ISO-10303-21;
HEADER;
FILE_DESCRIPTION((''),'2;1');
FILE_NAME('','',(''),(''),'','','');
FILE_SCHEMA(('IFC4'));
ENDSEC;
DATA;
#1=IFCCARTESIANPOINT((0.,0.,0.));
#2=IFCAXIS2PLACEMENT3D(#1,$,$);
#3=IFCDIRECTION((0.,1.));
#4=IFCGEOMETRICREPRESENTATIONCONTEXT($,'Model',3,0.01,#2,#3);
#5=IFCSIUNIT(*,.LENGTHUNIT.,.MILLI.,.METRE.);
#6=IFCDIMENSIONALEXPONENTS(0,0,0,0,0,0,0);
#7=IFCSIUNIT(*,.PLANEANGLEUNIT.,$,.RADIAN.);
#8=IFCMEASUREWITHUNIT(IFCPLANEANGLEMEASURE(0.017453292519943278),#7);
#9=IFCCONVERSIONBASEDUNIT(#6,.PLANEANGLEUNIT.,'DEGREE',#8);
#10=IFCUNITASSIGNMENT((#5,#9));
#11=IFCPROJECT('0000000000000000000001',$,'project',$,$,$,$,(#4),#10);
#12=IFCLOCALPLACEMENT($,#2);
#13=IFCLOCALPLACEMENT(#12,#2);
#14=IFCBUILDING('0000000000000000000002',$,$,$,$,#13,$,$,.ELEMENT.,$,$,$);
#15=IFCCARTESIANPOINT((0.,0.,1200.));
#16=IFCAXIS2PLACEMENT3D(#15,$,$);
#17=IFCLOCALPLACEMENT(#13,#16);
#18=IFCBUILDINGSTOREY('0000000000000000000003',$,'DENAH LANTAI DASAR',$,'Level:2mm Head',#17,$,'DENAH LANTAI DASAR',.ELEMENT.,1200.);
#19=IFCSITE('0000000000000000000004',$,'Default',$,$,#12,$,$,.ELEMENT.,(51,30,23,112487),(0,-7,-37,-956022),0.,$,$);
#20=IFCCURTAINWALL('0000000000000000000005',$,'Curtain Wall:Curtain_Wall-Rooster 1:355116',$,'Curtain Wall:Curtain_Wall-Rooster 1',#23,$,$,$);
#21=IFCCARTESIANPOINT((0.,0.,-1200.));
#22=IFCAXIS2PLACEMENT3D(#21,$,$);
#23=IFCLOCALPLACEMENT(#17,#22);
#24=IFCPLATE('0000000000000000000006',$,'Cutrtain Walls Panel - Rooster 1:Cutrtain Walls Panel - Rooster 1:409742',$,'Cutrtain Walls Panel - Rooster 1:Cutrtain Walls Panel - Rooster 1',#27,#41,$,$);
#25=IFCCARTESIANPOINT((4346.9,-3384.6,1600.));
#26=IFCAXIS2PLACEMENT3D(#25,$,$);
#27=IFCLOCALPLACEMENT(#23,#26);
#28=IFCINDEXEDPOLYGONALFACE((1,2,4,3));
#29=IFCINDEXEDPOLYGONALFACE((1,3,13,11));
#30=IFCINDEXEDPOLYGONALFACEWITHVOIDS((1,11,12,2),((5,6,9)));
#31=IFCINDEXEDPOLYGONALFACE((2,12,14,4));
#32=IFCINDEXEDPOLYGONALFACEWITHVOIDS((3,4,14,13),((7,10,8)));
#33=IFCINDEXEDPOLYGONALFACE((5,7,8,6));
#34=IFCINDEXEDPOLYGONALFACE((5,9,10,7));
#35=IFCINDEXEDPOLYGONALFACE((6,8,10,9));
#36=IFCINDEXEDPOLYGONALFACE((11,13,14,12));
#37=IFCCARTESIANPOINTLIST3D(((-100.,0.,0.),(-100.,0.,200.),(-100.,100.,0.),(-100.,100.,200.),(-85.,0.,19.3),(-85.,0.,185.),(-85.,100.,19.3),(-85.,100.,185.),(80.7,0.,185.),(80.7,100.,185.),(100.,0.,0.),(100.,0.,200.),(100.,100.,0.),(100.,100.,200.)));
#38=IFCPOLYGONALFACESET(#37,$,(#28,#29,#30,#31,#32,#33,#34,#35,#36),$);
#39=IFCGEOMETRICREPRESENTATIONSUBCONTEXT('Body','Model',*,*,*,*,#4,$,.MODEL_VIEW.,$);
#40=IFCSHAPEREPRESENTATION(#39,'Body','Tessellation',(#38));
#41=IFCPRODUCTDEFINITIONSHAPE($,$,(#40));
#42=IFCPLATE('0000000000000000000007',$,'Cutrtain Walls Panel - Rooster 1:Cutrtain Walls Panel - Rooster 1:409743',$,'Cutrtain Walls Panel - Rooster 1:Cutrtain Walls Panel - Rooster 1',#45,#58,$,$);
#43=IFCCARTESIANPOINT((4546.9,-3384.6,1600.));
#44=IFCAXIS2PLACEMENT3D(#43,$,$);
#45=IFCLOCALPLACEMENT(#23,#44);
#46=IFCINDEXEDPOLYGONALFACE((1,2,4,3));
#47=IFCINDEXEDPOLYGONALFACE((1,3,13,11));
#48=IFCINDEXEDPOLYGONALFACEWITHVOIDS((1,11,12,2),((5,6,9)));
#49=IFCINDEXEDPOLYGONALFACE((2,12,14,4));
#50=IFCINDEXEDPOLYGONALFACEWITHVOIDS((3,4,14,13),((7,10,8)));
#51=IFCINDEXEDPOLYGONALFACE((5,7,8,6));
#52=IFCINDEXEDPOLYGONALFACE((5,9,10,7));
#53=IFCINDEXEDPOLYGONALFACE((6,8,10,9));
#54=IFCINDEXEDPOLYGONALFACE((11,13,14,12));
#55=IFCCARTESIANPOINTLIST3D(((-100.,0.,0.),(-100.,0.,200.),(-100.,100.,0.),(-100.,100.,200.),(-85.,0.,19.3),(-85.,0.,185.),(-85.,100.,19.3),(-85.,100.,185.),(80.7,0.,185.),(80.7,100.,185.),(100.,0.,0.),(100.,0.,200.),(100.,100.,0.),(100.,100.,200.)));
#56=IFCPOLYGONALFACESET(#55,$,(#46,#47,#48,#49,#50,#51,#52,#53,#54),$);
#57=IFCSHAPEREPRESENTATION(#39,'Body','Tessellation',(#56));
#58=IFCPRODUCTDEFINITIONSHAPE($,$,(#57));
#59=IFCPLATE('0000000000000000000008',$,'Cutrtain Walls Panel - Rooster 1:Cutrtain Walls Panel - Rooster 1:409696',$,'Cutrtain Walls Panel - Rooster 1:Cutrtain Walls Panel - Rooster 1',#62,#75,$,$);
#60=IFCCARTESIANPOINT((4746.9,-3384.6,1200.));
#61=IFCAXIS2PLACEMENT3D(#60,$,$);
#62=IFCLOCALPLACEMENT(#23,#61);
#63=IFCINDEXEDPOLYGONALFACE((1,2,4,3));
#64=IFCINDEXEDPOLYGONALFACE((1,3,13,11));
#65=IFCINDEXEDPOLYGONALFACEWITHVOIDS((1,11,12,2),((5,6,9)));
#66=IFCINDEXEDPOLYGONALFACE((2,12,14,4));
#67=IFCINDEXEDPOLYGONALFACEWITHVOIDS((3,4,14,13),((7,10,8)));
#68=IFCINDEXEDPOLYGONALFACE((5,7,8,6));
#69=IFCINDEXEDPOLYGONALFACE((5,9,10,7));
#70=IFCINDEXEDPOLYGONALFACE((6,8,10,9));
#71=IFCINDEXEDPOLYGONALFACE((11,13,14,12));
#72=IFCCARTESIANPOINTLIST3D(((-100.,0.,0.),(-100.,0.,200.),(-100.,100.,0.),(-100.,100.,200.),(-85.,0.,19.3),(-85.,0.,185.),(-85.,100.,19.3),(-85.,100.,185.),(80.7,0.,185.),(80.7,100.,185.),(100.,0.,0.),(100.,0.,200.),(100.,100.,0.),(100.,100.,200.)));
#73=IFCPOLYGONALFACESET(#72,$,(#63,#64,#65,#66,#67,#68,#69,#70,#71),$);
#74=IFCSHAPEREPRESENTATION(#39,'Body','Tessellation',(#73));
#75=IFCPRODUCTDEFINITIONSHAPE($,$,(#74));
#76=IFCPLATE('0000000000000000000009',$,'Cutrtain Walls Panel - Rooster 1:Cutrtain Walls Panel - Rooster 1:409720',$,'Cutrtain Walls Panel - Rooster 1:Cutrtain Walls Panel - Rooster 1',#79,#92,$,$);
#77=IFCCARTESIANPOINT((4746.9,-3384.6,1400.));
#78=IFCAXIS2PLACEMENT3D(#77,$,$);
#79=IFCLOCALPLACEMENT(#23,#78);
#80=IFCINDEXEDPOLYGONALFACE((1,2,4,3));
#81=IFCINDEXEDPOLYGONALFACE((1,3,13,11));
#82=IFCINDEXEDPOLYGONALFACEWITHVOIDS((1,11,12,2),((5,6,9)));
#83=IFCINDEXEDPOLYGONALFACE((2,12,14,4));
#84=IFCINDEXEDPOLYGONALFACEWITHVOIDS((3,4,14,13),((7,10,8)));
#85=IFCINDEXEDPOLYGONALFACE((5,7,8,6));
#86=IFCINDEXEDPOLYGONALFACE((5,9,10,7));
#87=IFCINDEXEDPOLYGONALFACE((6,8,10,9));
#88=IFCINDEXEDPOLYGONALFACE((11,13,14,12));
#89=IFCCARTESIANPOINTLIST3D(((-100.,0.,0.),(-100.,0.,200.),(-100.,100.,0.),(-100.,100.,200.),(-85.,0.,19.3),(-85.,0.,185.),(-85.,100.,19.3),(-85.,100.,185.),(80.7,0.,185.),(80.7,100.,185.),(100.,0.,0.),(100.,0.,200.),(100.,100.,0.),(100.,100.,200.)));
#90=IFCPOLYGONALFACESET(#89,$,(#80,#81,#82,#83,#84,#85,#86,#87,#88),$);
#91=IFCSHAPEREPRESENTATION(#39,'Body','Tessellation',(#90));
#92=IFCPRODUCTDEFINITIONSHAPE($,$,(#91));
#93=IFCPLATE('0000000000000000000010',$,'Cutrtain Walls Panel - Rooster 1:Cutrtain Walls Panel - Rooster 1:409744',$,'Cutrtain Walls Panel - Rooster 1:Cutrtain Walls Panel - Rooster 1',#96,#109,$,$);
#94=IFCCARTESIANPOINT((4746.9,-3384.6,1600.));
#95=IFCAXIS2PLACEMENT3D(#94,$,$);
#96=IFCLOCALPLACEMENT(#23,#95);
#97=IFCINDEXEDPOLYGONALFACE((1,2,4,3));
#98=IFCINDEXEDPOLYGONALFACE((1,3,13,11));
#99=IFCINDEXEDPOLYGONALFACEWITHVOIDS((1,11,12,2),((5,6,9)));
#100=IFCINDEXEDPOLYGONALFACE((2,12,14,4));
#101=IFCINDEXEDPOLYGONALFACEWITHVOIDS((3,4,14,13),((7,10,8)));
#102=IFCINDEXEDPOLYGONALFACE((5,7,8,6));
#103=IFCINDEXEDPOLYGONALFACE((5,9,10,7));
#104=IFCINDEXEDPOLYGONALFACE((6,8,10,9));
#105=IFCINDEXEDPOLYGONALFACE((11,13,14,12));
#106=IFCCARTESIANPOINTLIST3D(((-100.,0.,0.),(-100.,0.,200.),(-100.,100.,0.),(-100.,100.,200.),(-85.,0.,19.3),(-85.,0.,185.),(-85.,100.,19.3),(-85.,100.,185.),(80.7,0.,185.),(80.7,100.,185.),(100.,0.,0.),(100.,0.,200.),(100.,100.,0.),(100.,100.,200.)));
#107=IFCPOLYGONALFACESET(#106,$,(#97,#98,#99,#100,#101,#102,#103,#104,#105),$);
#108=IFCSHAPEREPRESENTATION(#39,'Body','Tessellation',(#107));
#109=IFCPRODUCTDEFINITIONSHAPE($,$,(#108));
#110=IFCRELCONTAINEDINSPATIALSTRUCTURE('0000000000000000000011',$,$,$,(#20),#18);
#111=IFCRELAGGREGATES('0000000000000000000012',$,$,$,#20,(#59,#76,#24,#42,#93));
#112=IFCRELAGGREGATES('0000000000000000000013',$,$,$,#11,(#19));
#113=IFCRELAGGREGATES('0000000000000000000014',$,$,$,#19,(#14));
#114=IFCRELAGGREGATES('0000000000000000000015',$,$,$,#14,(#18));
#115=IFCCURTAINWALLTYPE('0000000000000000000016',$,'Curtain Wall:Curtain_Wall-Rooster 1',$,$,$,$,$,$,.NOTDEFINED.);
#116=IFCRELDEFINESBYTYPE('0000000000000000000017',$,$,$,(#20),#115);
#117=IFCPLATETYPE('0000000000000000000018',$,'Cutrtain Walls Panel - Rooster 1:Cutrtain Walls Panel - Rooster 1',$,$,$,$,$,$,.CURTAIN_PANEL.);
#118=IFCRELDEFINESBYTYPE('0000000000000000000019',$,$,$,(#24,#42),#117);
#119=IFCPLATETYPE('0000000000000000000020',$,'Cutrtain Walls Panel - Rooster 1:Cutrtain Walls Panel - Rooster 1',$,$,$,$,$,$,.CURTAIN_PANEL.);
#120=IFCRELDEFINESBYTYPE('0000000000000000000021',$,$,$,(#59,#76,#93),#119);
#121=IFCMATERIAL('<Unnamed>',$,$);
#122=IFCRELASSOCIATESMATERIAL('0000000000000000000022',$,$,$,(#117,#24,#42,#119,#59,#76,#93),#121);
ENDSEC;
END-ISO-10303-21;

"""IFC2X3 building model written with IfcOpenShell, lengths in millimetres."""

from ifc_helpers import new_model, entity, si_unit, converted_unit, direction, frame, origin, place, context, subcontext, project, spatial, polyline, outline, extrude, source, transform, mapped, material, type_object, type_shapes, element, aggregate, save


model = new_model("IFC2X3")

# Units and contexts
model_context = context("Model", 3, precision=0.01, world=origin(), true_north=direction((0.0, 1.0)))
body_context = subcontext(model_context, "Body", "Model", "MODEL_VIEW")
ifc_project = project(units=[si_unit("LENGTHUNIT", "METRE", prefix="MILLI"), converted_unit("PLANEANGLEUNIT", "DEGREE", entity("IfcPlaneAngleMeasure", 0.017453292519943278), si_unit("PLANEANGLEUNIT", "RADIAN"), dimensions=[0, 0, 0, 0, 0, 0, 0])], contexts=[model_context])

# Site, building, storey
site_placement = place(None, origin())
site = spatial("IfcSite", under=ifc_project, at=site_placement, Name="Default", CompositionType="ELEMENT", RefLatitude=(51, 30, 23, 112487), RefLongitude=(0, -7, -37, -956022), RefElevation=0.0)
building_placement = place(site_placement, origin())
building = spatial("IfcBuilding", under=site, at=building_placement, CompositionType="ELEMENT")
storey_placement = place(building_placement, frame((0.0, 0.0, 1200.0)))
storey = spatial("IfcBuildingStorey", under=building, at=storey_placement, Name="DENAH LANTAI DASAR", ObjectType="Level:2mm Head", LongName="DENAH LANTAI DASAR", CompositionType="ELEMENT", Elevation=1200.0)

# Curtain wall, plates
curtain_wall_type = type_object("IfcCurtainWallType", Name="Curtain Wall:Curtain_Wall-Rooster 1", PredefinedType="NOTDEFINED")
curtain_wall_placement = place(storey_placement, frame((0.0, 0.0, -1200.0)))
curtain_wall = element("IfcCurtainWall", 1, at=curtain_wall_placement, inside=storey, type_object=curtain_wall_type, Name="Curtain Wall:Curtain_Wall-Rooster 1:355116", ObjectType="Curtain Wall:Curtain_Wall-Rooster 1")
ifc_material = material(Name="<Unnamed>")
plate_type_1 = type_object("IfcPlateType", Name="Cutrtain Walls Panel - Rooster 1:Cutrtain Walls Panel - Rooster 1", PredefinedType="CURTAIN_PANEL", material=ifc_material)
shared_shape_1 = source(origin(), body_context, "Body", "SweptSolid", [
    extrude(outline(polyline([(-100.0, -100.0), (100.0, -100.0), (100.0, 100.0), (-100.0, 100.0), (-100.0, -100.0)]), holes=[polyline([(80.7, 85.0), (-85.0, -80.7), (-85.0, 85.0), (80.7, 85.0)])]), frame((0.0, 0.0, 100.0), z_axis=(0.0, 1.0, 0.0), x_axis=(0.0, 0.0, -1.0)), (0.0, 0.0, 1.0), 100.0),
])
type_shapes(plate_type_1, [shared_shape_1])
plate_1_placement = place(curtain_wall_placement, frame((4346.9, -3384.6, 1600.0)))
plate_1 = element("IfcPlate", 2, at=plate_1_placement, type_object=plate_type_1, material=ifc_material, Name="Cutrtain Walls Panel - Rooster 1:Cutrtain Walls Panel - Rooster 1:409742", ObjectType="Cutrtain Walls Panel - Rooster 1:Cutrtain Walls Panel - Rooster 1", context=body_context, shape_type="MappedRepresentation", body=[
    mapped(shared_shape_1, transform((0.0, 0.0, 0.0), scale=1.0)),
])
plate_2_placement = place(curtain_wall_placement, frame((4546.9, -3384.6, 1600.0)))
plate_2 = element("IfcPlate", 3, at=plate_2_placement, type_object=plate_type_1, material=ifc_material, Name="Cutrtain Walls Panel - Rooster 1:Cutrtain Walls Panel - Rooster 1:409743", ObjectType="Cutrtain Walls Panel - Rooster 1:Cutrtain Walls Panel - Rooster 1", context=body_context, shape_type="MappedRepresentation", body=[
    mapped(shared_shape_1, transform((0.0, 0.0, 0.0), scale=1.0)),
])
plate_type_2 = type_object("IfcPlateType", Name="Cutrtain Walls Panel - Rooster 1:Cutrtain Walls Panel - Rooster 1", PredefinedType="CURTAIN_PANEL", material=ifc_material)
shared_shape_2 = source(origin(), body_context, "Body", "SweptSolid", [
    extrude(outline(polyline([(-100.0, -100.0), (100.0, -100.0), (100.0, 100.0), (-100.0, 100.0), (-100.0, -100.0)]), holes=[polyline([(80.7, 85.0), (-85.0, -80.7), (-85.0, 85.0), (80.7, 85.0)])]), frame((0.0, 0.0, 100.0), z_axis=(0.0, 1.0, 0.0), x_axis=(0.0, 0.0, -1.0)), (0.0, 0.0, 1.0), 100.0),
])
type_shapes(plate_type_2, [shared_shape_2])
plate_3_placement = place(curtain_wall_placement, frame((4746.9, -3384.6, 1200.0)))
plate_3 = element("IfcPlate", 4, at=plate_3_placement, type_object=plate_type_2, material=ifc_material, Name="Cutrtain Walls Panel - Rooster 1:Cutrtain Walls Panel - Rooster 1:409696", ObjectType="Cutrtain Walls Panel - Rooster 1:Cutrtain Walls Panel - Rooster 1", context=body_context, shape_type="MappedRepresentation", body=[
    mapped(shared_shape_2, transform((0.0, 0.0, 0.0), scale=1.0)),
])
plate_4_placement = place(curtain_wall_placement, frame((4746.9, -3384.6, 1400.0)))
plate_4 = element("IfcPlate", 5, at=plate_4_placement, type_object=plate_type_2, material=ifc_material, Name="Cutrtain Walls Panel - Rooster 1:Cutrtain Walls Panel - Rooster 1:409720", ObjectType="Cutrtain Walls Panel - Rooster 1:Cutrtain Walls Panel - Rooster 1", context=body_context, shape_type="MappedRepresentation", body=[
    mapped(shared_shape_2, transform((0.0, 0.0, 0.0), scale=1.0)),
])
plate_5_placement = place(curtain_wall_placement, frame((4746.9, -3384.6, 1600.0)))
plate_5 = element("IfcPlate", 6, at=plate_5_placement, type_object=plate_type_2, material=ifc_material, Name="Cutrtain Walls Panel - Rooster 1:Cutrtain Walls Panel - Rooster 1:409744", ObjectType="Cutrtain Walls Panel - Rooster 1:Cutrtain Walls Panel - Rooster 1", context=body_context, shape_type="MappedRepresentation", body=[
    mapped(shared_shape_2, transform((0.0, 0.0, 0.0), scale=1.0)),
])
aggregate(curtain_wall, [plate_3, plate_4, plate_1, plate_2, plate_5])

save(model, "model.ifc")
